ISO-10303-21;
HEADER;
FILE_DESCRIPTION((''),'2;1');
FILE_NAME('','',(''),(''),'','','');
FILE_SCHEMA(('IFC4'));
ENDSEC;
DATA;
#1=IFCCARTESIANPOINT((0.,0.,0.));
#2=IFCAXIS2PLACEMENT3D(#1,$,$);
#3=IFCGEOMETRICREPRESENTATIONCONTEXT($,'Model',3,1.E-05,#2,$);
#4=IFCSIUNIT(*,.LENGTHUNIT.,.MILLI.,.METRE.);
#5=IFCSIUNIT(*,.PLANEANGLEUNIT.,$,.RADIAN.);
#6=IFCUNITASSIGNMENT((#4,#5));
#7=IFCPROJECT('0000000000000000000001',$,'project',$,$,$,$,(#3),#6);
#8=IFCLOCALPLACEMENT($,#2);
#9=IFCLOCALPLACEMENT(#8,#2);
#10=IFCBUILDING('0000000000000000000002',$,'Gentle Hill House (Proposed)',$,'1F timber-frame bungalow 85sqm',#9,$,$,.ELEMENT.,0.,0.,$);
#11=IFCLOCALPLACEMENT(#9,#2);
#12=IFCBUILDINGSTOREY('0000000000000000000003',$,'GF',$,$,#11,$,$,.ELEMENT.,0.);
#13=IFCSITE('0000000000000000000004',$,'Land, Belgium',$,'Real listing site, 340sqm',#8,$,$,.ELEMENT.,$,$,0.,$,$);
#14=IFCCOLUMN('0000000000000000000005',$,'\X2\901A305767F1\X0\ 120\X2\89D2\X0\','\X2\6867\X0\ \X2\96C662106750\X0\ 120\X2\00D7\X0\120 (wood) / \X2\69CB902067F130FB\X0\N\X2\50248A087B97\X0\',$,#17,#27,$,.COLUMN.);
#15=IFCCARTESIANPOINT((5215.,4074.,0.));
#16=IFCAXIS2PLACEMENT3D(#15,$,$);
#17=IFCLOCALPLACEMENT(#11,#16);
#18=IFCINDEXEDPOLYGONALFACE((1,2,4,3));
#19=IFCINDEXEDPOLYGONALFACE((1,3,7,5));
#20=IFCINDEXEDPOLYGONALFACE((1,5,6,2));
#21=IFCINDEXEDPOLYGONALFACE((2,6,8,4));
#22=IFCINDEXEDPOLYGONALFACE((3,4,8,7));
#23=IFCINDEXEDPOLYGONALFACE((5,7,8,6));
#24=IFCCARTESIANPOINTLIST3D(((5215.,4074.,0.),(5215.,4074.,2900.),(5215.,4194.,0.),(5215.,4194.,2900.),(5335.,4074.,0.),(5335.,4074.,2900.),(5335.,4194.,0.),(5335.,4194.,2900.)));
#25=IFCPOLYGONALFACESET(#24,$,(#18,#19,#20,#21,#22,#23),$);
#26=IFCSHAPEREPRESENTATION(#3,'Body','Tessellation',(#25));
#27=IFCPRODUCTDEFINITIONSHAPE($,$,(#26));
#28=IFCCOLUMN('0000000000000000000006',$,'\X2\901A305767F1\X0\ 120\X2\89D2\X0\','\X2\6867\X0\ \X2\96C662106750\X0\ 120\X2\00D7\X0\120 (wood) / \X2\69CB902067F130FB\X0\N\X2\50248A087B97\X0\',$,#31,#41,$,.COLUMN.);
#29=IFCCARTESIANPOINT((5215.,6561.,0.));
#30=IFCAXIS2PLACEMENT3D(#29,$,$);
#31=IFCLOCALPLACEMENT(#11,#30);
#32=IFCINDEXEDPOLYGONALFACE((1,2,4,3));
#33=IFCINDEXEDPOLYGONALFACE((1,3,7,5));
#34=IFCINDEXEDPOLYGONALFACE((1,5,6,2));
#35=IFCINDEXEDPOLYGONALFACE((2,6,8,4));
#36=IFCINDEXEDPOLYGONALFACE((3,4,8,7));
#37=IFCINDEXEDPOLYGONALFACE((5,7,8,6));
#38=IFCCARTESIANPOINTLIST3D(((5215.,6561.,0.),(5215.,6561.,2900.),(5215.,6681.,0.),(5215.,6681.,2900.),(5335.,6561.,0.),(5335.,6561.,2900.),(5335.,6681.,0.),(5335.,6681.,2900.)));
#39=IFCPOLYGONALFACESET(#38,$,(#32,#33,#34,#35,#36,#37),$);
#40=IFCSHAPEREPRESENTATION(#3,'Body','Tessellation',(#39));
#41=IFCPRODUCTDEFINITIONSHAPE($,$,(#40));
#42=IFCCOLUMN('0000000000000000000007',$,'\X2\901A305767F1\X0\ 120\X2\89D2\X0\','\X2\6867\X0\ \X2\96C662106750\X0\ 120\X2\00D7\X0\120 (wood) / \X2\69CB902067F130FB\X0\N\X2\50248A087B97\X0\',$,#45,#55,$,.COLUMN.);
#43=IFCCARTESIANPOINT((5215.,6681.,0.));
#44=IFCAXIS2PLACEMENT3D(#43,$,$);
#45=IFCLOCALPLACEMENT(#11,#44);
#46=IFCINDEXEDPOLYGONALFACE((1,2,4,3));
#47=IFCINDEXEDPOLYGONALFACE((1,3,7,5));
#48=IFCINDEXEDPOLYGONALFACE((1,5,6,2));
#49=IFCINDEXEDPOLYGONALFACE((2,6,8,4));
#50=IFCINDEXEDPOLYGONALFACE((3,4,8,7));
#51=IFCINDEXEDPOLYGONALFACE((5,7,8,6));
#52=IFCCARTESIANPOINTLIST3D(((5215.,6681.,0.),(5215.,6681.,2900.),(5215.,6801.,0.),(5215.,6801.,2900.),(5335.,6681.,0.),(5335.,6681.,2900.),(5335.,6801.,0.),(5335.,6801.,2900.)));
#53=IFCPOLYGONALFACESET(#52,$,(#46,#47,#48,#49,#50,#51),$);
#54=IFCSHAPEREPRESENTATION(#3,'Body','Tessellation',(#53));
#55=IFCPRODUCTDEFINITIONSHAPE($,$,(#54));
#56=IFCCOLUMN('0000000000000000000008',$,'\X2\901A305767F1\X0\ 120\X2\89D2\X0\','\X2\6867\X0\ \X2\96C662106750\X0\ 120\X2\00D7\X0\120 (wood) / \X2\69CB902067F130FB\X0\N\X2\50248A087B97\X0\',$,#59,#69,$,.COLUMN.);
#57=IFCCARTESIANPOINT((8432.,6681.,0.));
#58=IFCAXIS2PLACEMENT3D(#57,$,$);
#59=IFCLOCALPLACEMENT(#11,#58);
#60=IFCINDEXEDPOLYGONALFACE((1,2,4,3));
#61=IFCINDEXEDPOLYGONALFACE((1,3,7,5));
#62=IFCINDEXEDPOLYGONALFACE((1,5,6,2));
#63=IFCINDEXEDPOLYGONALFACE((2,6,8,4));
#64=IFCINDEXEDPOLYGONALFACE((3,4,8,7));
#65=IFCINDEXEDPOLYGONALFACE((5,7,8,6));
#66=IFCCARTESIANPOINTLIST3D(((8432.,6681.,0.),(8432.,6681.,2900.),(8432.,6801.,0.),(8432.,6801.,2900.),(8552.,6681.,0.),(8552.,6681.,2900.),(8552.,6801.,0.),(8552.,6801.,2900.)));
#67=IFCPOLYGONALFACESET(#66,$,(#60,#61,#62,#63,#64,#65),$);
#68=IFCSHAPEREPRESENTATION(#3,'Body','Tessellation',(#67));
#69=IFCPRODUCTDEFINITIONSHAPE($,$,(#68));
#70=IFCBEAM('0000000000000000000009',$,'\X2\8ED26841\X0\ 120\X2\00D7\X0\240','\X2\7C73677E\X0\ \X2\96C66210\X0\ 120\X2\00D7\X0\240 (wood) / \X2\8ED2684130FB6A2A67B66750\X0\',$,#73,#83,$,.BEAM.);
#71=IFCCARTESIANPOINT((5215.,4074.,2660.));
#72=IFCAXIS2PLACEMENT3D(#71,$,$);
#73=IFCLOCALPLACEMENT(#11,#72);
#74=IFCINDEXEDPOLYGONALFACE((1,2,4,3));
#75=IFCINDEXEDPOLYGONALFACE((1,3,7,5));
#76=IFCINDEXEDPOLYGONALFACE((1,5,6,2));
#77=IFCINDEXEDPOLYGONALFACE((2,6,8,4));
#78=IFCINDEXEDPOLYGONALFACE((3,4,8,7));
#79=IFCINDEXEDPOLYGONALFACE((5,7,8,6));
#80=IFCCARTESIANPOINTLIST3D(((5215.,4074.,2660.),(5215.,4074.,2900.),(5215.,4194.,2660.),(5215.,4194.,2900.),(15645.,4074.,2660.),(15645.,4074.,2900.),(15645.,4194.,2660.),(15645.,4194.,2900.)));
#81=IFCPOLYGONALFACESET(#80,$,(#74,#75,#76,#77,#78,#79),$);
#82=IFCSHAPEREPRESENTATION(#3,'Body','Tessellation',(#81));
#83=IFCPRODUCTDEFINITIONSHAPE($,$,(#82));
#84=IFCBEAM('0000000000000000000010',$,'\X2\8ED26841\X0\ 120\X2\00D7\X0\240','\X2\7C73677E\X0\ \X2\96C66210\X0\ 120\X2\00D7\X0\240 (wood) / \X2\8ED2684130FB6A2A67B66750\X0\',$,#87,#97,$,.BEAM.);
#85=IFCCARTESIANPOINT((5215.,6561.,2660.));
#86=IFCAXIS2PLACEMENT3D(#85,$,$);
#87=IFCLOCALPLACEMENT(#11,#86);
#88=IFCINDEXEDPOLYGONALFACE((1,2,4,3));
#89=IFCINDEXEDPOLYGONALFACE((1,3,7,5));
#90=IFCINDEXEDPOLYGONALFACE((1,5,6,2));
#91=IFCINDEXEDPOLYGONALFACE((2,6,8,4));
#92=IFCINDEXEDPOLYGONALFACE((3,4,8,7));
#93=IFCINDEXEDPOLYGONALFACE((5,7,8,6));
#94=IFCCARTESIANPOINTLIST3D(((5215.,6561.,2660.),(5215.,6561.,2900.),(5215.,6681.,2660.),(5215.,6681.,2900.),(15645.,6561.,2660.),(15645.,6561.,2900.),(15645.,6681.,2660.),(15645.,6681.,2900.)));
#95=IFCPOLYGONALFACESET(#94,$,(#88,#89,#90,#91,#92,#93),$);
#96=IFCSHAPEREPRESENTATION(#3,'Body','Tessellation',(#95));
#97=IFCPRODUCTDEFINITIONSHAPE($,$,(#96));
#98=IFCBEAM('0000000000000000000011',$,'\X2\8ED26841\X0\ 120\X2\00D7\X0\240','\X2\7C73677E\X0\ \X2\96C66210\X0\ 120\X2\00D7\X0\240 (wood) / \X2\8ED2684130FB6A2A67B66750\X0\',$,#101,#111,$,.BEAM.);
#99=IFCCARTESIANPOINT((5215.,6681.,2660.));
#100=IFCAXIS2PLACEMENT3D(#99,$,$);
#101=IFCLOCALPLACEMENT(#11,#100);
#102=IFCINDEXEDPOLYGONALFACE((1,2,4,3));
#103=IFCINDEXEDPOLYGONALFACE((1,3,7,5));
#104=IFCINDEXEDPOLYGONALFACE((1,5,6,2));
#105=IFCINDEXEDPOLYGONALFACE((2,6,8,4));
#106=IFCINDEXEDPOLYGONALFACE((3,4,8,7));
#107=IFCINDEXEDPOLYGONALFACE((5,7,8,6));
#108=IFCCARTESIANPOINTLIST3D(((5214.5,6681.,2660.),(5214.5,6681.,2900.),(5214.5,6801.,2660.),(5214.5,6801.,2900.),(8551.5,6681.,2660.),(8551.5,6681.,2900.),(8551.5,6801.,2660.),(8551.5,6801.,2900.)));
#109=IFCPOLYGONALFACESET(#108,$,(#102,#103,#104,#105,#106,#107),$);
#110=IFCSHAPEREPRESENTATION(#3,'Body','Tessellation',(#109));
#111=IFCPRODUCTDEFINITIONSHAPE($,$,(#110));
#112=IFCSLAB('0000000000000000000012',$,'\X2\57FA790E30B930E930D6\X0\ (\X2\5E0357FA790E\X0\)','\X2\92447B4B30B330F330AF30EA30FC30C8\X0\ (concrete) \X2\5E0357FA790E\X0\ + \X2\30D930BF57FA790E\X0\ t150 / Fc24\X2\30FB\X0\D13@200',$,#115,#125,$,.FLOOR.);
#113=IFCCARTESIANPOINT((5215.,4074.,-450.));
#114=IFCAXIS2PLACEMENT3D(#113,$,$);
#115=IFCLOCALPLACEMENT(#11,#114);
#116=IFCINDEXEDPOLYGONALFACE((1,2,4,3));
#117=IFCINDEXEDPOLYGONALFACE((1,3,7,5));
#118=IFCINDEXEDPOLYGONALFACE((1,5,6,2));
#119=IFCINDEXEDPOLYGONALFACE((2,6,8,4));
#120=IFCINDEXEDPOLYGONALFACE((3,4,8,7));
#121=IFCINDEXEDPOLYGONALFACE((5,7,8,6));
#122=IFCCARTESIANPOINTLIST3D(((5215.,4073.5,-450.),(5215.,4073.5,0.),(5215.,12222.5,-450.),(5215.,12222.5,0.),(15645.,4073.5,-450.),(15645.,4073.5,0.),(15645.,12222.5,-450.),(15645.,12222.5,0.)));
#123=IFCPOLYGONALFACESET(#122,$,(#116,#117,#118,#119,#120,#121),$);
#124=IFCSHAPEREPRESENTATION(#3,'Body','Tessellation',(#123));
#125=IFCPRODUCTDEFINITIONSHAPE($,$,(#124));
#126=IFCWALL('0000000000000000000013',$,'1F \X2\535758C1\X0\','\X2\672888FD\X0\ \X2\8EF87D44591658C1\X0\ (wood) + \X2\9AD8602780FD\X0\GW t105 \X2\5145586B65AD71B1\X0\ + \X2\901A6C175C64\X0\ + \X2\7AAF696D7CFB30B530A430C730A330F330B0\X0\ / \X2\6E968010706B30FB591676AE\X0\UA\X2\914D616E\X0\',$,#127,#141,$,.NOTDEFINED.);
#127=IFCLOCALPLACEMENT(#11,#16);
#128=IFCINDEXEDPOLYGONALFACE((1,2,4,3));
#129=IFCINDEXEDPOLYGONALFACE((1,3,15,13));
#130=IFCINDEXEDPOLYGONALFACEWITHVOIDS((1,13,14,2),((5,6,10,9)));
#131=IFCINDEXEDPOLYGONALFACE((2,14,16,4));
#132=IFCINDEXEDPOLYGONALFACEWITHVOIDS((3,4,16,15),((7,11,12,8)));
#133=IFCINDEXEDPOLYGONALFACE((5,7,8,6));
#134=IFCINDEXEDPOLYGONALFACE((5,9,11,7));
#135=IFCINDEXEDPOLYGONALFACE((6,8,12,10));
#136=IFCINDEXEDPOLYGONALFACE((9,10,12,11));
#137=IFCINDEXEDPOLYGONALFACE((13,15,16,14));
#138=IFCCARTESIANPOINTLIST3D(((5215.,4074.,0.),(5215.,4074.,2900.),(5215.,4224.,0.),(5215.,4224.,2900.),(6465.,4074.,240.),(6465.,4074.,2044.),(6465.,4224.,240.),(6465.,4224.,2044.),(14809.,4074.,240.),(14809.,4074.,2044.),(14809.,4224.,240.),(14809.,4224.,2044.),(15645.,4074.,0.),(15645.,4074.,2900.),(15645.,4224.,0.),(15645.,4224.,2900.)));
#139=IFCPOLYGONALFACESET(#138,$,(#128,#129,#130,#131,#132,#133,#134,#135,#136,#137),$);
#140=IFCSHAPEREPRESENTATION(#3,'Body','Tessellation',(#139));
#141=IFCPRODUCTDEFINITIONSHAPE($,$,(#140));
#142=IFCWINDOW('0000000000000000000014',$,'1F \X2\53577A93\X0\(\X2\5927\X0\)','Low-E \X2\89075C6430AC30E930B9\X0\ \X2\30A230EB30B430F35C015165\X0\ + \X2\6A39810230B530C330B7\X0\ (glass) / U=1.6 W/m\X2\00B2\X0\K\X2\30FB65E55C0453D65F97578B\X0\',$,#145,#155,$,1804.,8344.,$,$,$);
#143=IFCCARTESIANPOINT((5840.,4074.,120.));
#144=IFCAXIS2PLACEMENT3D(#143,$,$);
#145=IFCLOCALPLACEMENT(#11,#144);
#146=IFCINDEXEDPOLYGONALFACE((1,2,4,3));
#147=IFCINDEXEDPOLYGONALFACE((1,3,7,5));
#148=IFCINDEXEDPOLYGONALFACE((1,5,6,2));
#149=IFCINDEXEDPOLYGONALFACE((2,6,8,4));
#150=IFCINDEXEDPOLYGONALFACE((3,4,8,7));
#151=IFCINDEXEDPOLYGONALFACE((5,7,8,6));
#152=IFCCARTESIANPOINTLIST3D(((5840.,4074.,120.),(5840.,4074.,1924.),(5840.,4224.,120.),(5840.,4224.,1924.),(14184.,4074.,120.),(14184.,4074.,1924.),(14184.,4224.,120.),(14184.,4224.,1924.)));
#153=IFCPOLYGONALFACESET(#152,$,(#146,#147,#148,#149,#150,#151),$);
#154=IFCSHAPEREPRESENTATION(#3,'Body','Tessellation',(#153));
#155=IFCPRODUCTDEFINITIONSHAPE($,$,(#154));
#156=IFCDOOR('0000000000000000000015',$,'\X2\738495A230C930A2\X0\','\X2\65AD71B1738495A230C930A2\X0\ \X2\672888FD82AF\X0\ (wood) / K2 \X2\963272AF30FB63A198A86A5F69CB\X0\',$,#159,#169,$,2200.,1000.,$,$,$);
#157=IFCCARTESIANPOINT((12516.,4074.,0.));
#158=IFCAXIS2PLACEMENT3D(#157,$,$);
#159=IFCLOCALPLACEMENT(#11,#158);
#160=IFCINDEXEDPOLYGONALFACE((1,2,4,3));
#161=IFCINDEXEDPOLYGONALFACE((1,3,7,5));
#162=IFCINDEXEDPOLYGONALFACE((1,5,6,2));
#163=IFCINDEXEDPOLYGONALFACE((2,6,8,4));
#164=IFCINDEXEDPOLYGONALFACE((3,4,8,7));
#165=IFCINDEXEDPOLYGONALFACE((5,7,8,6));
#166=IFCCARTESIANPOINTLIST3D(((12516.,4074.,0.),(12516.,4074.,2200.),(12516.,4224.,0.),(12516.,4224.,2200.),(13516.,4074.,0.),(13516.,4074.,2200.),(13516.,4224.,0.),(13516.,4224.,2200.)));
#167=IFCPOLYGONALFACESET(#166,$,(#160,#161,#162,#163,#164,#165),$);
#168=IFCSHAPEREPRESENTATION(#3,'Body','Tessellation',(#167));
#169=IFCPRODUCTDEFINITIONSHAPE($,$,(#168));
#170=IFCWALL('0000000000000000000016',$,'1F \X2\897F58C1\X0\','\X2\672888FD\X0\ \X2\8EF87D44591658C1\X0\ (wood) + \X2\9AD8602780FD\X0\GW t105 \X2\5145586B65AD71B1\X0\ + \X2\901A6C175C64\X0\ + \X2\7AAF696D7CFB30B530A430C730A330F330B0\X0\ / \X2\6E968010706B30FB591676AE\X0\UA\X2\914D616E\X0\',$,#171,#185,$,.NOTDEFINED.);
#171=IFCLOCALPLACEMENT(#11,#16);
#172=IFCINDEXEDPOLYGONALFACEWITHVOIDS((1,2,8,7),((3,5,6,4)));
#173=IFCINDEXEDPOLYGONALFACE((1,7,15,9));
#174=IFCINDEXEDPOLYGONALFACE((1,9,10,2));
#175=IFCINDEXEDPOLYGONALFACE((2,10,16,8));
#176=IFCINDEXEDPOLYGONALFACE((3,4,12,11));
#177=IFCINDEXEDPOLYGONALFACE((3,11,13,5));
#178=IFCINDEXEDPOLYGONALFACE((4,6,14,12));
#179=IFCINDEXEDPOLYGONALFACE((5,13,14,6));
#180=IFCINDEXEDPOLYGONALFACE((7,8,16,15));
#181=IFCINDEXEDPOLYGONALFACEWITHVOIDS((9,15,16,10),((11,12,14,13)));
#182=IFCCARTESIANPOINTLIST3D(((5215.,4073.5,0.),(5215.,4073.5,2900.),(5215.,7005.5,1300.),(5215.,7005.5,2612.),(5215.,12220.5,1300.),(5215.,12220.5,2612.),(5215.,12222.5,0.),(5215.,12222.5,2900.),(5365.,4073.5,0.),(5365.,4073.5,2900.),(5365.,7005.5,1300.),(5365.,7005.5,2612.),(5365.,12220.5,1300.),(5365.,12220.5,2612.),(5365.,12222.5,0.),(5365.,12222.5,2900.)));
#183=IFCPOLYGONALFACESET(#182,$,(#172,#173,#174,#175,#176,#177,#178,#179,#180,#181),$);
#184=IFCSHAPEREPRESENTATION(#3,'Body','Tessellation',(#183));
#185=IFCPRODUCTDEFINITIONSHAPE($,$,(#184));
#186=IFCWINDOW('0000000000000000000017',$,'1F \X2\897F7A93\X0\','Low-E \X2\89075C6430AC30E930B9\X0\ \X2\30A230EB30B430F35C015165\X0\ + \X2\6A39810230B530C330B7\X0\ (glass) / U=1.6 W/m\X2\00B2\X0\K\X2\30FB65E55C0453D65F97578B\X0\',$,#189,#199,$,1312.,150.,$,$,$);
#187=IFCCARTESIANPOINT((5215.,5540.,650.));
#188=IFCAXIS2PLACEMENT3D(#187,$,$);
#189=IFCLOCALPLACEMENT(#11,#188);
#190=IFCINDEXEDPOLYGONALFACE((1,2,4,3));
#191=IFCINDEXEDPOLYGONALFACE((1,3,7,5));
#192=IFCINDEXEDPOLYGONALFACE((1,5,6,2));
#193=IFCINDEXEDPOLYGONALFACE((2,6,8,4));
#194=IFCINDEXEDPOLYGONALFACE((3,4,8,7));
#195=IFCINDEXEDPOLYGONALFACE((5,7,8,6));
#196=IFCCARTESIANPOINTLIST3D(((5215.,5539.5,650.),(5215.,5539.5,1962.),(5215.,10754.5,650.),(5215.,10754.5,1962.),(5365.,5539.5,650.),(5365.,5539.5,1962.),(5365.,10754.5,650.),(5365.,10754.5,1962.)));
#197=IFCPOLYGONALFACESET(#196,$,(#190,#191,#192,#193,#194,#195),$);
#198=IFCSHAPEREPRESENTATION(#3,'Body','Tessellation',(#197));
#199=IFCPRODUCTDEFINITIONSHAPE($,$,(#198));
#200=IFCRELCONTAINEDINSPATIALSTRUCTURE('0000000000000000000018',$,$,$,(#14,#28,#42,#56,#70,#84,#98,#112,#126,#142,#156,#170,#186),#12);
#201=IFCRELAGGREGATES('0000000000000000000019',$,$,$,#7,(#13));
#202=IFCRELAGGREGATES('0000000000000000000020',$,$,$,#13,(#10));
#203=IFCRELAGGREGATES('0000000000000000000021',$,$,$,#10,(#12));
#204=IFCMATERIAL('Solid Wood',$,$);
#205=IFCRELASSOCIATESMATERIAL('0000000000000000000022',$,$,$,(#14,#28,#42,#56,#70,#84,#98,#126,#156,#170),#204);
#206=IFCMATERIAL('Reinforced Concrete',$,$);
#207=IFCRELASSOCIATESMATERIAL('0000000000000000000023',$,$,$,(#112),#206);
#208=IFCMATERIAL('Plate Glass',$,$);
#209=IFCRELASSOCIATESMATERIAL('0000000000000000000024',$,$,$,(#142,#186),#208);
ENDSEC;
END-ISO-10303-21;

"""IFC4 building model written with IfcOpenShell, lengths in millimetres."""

from ifc_helpers import new_model, si_unit, frame, frame_2d, origin, place, context, project, spatial, rectangle, extrude, material, element, fill, save


model = new_model("IFC4")

# Units and contexts
model_context = context("Model", 3, precision=1e-05, world=origin())
ifc_project = project(units=[si_unit("LENGTHUNIT", "METRE", prefix="MILLI"), si_unit("PLANEANGLEUNIT", "RADIAN")], contexts=[model_context])

# Site, building, storey
site_placement = place(None, origin())
site = spatial("IfcSite", under=ifc_project, at=site_placement, Name="Land, Belgium", ObjectType="Real listing site, 340sqm", CompositionType="ELEMENT", RefElevation=0.0)
building_placement = place(site_placement, origin())
building = spatial("IfcBuilding", under=site, at=building_placement, Name="Gentle Hill House (Proposed)", ObjectType="1F timber-frame bungalow 85sqm", CompositionType="ELEMENT", ElevationOfRefHeight=0.0, ElevationOfTerrain=0.0)
storey_placement = place(building_placement, origin())
storey = spatial("IfcBuildingStorey", under=building, at=storey_placement, Name="GF", CompositionType="ELEMENT", Elevation=0.0)

# Columns
ifc_material_1 = material(Name="Solid Wood")
column_1_placement = place(storey_placement, frame((5215.0, 4074.0, 0.0)))
element("IfcColumn", 1, at=column_1_placement, inside=storey, material=ifc_material_1, Name="通し柱 120角", Description="桧 集成材 120×120 (wood) / 構造柱・N値計算", PredefinedType="COLUMN", context=model_context, shape_type="SweptSolid", body=[
    extrude(rectangle(XDim=120.0, YDim=120.0, at=frame_2d((60.0, 60.0))), frame((5215.0, 4074.0, 0.0)), (0.0, 0.0, 1.0), 2900.0),
])
column_2_placement = place(storey_placement, frame((5215.0, 6561.0, 0.0)))
element("IfcColumn", 2, at=column_2_placement, inside=storey, material=ifc_material_1, Name="通し柱 120角", Description="桧 集成材 120×120 (wood) / 構造柱・N値計算", PredefinedType="COLUMN", context=model_context, shape_type="SweptSolid", body=[
    extrude(rectangle(XDim=120.0, YDim=120.0, at=frame_2d((60.0, 60.0))), frame((5215.0, 6561.0, 0.0)), (0.0, 0.0, 1.0), 2900.0),
])
column_3_placement = place(storey_placement, frame((5215.0, 6681.0, 0.0)))
element("IfcColumn", 3, at=column_3_placement, inside=storey, material=ifc_material_1, Name="通し柱 120角", Description="桧 集成材 120×120 (wood) / 構造柱・N値計算", PredefinedType="COLUMN", context=model_context, shape_type="SweptSolid", body=[
    extrude(rectangle(XDim=120.0, YDim=120.0, at=frame_2d((60.0, 60.0))), frame((5215.0, 6681.0, 0.0)), (0.0, 0.0, 1.0), 2900.0),
])
column_4_placement = place(storey_placement, frame((8432.0, 6681.0, 0.0)))
element("IfcColumn", 4, at=column_4_placement, inside=storey, material=ifc_material_1, Name="通し柱 120角", Description="桧 集成材 120×120 (wood) / 構造柱・N値計算", PredefinedType="COLUMN", context=model_context, shape_type="SweptSolid", body=[
    extrude(rectangle(XDim=120.0, YDim=120.0, at=frame_2d((60.0, 60.0))), frame((8432.0, 6681.0, 0.0)), (0.0, 0.0, 1.0), 2900.0),
])

# Beams
beam_1_placement = place(storey_placement, frame((5215.0, 4074.0, 2660.0)))
element("IfcBeam", 5, at=beam_1_placement, inside=storey, material=ifc_material_1, Name="軒桁 120×240", Description="米松 集成 120×240 (wood) / 軒桁・横架材", PredefinedType="BEAM", context=model_context, shape_type="SweptSolid", body=[
    extrude(rectangle(XDim=10430.0, YDim=120.0, at=frame_2d((5215.0, 60.0))), frame((5215.0, 4074.0, 2660.0)), (0.0, 0.0, 1.0), 240.0),
])
beam_2_placement = place(storey_placement, frame((5215.0, 6561.0, 2660.0)))
element("IfcBeam", 6, at=beam_2_placement, inside=storey, material=ifc_material_1, Name="軒桁 120×240", Description="米松 集成 120×240 (wood) / 軒桁・横架材", PredefinedType="BEAM", context=model_context, shape_type="SweptSolid", body=[
    extrude(rectangle(XDim=10430.0, YDim=120.0, at=frame_2d((5215.0, 60.0))), frame((5215.0, 6561.0, 2660.0)), (0.0, 0.0, 1.0), 240.0),
])
beam_3_placement = place(storey_placement, frame((5215.0, 6681.0, 2660.0)))
element("IfcBeam", 7, at=beam_3_placement, inside=storey, material=ifc_material_1, Name="軒桁 120×240", Description="米松 集成 120×240 (wood) / 軒桁・横架材", PredefinedType="BEAM", context=model_context, shape_type="SweptSolid", body=[
    extrude(rectangle(XDim=3337.0, YDim=120.0, at=frame_2d((1668.0, 60.0))), frame((5215.0, 6681.0, 2660.0)), (0.0, 0.0, 1.0), 240.0),
])

# Slab
ifc_material_2 = material(Name="Reinforced Concrete")
slab_1_placement = place(storey_placement, frame((5215.0, 4074.0, -450.0)))
element("IfcSlab", 8, at=slab_1_placement, inside=storey, material=ifc_material_2, Name="基礎スラブ (布基礎)", Description="鉄筋コンクリート (concrete) 布基礎 + ベタ基礎 t150 / Fc24・D13@200", PredefinedType="FLOOR", context=model_context, shape_type="SweptSolid", body=[
    extrude(rectangle(XDim=10430.0, YDim=8149.0, at=frame_2d((5215.0, 4074.0))), frame((5215.0, 4074.0, -450.0)), (0.0, 0.0, 1.0), 450.0),
])

# Wall, openings, window, door
wall_1_placement = place(storey_placement, frame((5215.0, 4074.0, 0.0)))
wall_1 = element("IfcWall", 9, at=wall_1_placement, inside=storey, material=ifc_material_1, Name="1F 南壁", Description="木製 軸組外壁 (wood) + 高性能GW t105 充填断熱 + 通気層 + 窯業系サイディング / 準耐火・外皮UA配慮", PredefinedType="NOTDEFINED", context=model_context, shape_type="SweptSolid", body=[
    extrude(rectangle(XDim=10430.0, YDim=150.0, at=frame_2d((5215.0, 75.0))), frame((5215.0, 4074.0, 0.0)), (0.0, 0.0, 1.0), 2900.0),
])
opening_1_placement = place(storey_placement, frame((5840.0, 4074.0, 120.0)))
opening_1 = element("IfcOpeningElement", 10, at=opening_1_placement, cuts=wall_1, PredefinedType="NOTDEFINED", context=model_context, shape_type="SweptSolid", body=[
    extrude(rectangle(XDim=8344.0, YDim=150.0, at=frame_2d((4172.0, 75.0))), frame((5840.0, 4074.0, 120.0)), (0.0, 0.0, 1.0), 1804.0),
])
opening_2_placement = place(storey_placement, frame((12516.0, 4074.0, 0.0)))
opening_2 = element("IfcOpeningElement", 11, at=opening_2_placement, cuts=wall_1, PredefinedType="NOTDEFINED", context=model_context, shape_type="SweptSolid", body=[
    extrude(rectangle(XDim=1000.0, YDim=150.0, at=frame_2d((500.0, 75.0))), frame((12516.0, 4074.0, 0.0)), (0.0, 0.0, 1.0), 2200.0),
])
ifc_material_3 = material(Name="Plate Glass")
window_1_placement = place(storey_placement, frame((5840.0, 4074.0, 120.0)))
window_1 = element("IfcWindow", 12, at=window_1_placement, inside=storey, material=ifc_material_3, Name="1F 南窓(大)", Description="Low-E 複層ガラス アルゴン封入 + 樹脂サッシ (glass) / U=1.6 W/m²K・日射取得型", OverallHeight=1804.0, OverallWidth=8344.0, context=model_context, shape_type="SweptSolid", body=[
    extrude(rectangle(XDim=8344.0, YDim=150.0, at=frame_2d((4172.0, 75.0))), frame((5840.0, 4074.0, 120.0)), (0.0, 0.0, 1.0), 1804.0),
])
fill(opening_1, window_1)
door_placement = place(storey_placement, frame((12516.0, 4074.0, 0.0)))
door = element("IfcDoor", 13, at=door_placement, inside=storey, material=ifc_material_1, Name="玄関ドア", Description="断熱玄関ドア 木製芯 (wood) / K2 防犯・採風機構", OverallHeight=2200.0, OverallWidth=1000.0, context=model_context, shape_type="SweptSolid", body=[
    extrude(rectangle(XDim=1000.0, YDim=150.0, at=frame_2d((500.0, 75.0))), frame((12516.0, 4074.0, 0.0)), (0.0, 0.0, 1.0), 2200.0),
])
fill(opening_2, door)

# Wall, opening, window
wall_2_placement = place(storey_placement, frame((5215.0, 4074.0, 0.0)))
wall_2 = element("IfcWall", 14, at=wall_2_placement, inside=storey, material=ifc_material_1, Name="1F 西壁", Description="木製 軸組外壁 (wood) + 高性能GW t105 充填断熱 + 通気層 + 窯業系サイディング / 準耐火・外皮UA配慮", PredefinedType="NOTDEFINED", context=model_context, shape_type="SweptSolid", body=[
    extrude(rectangle(XDim=150.0, YDim=8149.0, at=frame_2d((75.0, 4074.0))), frame((5215.0, 4074.0, 0.0)), (0.0, 0.0, 1.0), 2900.0),
])
opening_3_placement = place(storey_placement, frame((5215.0, 5540.0, 650.0)))
opening_3 = element("IfcOpeningElement", 15, at=opening_3_placement, cuts=wall_2, PredefinedType="NOTDEFINED", context=model_context, shape_type="SweptSolid", body=[
    extrude(rectangle(XDim=150.0, YDim=5215.0, at=frame_2d((75.0, 2607.0))), frame((5215.0, 5540.0, 650.0)), (0.0, 0.0, 1.0), 1312.0),
])
window_2_placement = place(storey_placement, frame((5215.0, 5540.0, 650.0)))
window_2 = element("IfcWindow", 16, at=window_2_placement, inside=storey, material=ifc_material_3, Name="1F 西窓", Description="Low-E 複層ガラス アルゴン封入 + 樹脂サッシ (glass) / U=1.6 W/m²K・日射取得型", OverallHeight=1312.0, OverallWidth=150.0, context=model_context, shape_type="SweptSolid", body=[
    extrude(rectangle(XDim=150.0, YDim=5215.0, at=frame_2d((75.0, 2607.0))), frame((5215.0, 5540.0, 650.0)), (0.0, 0.0, 1.0), 1312.0),
])
fill(opening_3, window_2)

save(model, "model.ifc")
